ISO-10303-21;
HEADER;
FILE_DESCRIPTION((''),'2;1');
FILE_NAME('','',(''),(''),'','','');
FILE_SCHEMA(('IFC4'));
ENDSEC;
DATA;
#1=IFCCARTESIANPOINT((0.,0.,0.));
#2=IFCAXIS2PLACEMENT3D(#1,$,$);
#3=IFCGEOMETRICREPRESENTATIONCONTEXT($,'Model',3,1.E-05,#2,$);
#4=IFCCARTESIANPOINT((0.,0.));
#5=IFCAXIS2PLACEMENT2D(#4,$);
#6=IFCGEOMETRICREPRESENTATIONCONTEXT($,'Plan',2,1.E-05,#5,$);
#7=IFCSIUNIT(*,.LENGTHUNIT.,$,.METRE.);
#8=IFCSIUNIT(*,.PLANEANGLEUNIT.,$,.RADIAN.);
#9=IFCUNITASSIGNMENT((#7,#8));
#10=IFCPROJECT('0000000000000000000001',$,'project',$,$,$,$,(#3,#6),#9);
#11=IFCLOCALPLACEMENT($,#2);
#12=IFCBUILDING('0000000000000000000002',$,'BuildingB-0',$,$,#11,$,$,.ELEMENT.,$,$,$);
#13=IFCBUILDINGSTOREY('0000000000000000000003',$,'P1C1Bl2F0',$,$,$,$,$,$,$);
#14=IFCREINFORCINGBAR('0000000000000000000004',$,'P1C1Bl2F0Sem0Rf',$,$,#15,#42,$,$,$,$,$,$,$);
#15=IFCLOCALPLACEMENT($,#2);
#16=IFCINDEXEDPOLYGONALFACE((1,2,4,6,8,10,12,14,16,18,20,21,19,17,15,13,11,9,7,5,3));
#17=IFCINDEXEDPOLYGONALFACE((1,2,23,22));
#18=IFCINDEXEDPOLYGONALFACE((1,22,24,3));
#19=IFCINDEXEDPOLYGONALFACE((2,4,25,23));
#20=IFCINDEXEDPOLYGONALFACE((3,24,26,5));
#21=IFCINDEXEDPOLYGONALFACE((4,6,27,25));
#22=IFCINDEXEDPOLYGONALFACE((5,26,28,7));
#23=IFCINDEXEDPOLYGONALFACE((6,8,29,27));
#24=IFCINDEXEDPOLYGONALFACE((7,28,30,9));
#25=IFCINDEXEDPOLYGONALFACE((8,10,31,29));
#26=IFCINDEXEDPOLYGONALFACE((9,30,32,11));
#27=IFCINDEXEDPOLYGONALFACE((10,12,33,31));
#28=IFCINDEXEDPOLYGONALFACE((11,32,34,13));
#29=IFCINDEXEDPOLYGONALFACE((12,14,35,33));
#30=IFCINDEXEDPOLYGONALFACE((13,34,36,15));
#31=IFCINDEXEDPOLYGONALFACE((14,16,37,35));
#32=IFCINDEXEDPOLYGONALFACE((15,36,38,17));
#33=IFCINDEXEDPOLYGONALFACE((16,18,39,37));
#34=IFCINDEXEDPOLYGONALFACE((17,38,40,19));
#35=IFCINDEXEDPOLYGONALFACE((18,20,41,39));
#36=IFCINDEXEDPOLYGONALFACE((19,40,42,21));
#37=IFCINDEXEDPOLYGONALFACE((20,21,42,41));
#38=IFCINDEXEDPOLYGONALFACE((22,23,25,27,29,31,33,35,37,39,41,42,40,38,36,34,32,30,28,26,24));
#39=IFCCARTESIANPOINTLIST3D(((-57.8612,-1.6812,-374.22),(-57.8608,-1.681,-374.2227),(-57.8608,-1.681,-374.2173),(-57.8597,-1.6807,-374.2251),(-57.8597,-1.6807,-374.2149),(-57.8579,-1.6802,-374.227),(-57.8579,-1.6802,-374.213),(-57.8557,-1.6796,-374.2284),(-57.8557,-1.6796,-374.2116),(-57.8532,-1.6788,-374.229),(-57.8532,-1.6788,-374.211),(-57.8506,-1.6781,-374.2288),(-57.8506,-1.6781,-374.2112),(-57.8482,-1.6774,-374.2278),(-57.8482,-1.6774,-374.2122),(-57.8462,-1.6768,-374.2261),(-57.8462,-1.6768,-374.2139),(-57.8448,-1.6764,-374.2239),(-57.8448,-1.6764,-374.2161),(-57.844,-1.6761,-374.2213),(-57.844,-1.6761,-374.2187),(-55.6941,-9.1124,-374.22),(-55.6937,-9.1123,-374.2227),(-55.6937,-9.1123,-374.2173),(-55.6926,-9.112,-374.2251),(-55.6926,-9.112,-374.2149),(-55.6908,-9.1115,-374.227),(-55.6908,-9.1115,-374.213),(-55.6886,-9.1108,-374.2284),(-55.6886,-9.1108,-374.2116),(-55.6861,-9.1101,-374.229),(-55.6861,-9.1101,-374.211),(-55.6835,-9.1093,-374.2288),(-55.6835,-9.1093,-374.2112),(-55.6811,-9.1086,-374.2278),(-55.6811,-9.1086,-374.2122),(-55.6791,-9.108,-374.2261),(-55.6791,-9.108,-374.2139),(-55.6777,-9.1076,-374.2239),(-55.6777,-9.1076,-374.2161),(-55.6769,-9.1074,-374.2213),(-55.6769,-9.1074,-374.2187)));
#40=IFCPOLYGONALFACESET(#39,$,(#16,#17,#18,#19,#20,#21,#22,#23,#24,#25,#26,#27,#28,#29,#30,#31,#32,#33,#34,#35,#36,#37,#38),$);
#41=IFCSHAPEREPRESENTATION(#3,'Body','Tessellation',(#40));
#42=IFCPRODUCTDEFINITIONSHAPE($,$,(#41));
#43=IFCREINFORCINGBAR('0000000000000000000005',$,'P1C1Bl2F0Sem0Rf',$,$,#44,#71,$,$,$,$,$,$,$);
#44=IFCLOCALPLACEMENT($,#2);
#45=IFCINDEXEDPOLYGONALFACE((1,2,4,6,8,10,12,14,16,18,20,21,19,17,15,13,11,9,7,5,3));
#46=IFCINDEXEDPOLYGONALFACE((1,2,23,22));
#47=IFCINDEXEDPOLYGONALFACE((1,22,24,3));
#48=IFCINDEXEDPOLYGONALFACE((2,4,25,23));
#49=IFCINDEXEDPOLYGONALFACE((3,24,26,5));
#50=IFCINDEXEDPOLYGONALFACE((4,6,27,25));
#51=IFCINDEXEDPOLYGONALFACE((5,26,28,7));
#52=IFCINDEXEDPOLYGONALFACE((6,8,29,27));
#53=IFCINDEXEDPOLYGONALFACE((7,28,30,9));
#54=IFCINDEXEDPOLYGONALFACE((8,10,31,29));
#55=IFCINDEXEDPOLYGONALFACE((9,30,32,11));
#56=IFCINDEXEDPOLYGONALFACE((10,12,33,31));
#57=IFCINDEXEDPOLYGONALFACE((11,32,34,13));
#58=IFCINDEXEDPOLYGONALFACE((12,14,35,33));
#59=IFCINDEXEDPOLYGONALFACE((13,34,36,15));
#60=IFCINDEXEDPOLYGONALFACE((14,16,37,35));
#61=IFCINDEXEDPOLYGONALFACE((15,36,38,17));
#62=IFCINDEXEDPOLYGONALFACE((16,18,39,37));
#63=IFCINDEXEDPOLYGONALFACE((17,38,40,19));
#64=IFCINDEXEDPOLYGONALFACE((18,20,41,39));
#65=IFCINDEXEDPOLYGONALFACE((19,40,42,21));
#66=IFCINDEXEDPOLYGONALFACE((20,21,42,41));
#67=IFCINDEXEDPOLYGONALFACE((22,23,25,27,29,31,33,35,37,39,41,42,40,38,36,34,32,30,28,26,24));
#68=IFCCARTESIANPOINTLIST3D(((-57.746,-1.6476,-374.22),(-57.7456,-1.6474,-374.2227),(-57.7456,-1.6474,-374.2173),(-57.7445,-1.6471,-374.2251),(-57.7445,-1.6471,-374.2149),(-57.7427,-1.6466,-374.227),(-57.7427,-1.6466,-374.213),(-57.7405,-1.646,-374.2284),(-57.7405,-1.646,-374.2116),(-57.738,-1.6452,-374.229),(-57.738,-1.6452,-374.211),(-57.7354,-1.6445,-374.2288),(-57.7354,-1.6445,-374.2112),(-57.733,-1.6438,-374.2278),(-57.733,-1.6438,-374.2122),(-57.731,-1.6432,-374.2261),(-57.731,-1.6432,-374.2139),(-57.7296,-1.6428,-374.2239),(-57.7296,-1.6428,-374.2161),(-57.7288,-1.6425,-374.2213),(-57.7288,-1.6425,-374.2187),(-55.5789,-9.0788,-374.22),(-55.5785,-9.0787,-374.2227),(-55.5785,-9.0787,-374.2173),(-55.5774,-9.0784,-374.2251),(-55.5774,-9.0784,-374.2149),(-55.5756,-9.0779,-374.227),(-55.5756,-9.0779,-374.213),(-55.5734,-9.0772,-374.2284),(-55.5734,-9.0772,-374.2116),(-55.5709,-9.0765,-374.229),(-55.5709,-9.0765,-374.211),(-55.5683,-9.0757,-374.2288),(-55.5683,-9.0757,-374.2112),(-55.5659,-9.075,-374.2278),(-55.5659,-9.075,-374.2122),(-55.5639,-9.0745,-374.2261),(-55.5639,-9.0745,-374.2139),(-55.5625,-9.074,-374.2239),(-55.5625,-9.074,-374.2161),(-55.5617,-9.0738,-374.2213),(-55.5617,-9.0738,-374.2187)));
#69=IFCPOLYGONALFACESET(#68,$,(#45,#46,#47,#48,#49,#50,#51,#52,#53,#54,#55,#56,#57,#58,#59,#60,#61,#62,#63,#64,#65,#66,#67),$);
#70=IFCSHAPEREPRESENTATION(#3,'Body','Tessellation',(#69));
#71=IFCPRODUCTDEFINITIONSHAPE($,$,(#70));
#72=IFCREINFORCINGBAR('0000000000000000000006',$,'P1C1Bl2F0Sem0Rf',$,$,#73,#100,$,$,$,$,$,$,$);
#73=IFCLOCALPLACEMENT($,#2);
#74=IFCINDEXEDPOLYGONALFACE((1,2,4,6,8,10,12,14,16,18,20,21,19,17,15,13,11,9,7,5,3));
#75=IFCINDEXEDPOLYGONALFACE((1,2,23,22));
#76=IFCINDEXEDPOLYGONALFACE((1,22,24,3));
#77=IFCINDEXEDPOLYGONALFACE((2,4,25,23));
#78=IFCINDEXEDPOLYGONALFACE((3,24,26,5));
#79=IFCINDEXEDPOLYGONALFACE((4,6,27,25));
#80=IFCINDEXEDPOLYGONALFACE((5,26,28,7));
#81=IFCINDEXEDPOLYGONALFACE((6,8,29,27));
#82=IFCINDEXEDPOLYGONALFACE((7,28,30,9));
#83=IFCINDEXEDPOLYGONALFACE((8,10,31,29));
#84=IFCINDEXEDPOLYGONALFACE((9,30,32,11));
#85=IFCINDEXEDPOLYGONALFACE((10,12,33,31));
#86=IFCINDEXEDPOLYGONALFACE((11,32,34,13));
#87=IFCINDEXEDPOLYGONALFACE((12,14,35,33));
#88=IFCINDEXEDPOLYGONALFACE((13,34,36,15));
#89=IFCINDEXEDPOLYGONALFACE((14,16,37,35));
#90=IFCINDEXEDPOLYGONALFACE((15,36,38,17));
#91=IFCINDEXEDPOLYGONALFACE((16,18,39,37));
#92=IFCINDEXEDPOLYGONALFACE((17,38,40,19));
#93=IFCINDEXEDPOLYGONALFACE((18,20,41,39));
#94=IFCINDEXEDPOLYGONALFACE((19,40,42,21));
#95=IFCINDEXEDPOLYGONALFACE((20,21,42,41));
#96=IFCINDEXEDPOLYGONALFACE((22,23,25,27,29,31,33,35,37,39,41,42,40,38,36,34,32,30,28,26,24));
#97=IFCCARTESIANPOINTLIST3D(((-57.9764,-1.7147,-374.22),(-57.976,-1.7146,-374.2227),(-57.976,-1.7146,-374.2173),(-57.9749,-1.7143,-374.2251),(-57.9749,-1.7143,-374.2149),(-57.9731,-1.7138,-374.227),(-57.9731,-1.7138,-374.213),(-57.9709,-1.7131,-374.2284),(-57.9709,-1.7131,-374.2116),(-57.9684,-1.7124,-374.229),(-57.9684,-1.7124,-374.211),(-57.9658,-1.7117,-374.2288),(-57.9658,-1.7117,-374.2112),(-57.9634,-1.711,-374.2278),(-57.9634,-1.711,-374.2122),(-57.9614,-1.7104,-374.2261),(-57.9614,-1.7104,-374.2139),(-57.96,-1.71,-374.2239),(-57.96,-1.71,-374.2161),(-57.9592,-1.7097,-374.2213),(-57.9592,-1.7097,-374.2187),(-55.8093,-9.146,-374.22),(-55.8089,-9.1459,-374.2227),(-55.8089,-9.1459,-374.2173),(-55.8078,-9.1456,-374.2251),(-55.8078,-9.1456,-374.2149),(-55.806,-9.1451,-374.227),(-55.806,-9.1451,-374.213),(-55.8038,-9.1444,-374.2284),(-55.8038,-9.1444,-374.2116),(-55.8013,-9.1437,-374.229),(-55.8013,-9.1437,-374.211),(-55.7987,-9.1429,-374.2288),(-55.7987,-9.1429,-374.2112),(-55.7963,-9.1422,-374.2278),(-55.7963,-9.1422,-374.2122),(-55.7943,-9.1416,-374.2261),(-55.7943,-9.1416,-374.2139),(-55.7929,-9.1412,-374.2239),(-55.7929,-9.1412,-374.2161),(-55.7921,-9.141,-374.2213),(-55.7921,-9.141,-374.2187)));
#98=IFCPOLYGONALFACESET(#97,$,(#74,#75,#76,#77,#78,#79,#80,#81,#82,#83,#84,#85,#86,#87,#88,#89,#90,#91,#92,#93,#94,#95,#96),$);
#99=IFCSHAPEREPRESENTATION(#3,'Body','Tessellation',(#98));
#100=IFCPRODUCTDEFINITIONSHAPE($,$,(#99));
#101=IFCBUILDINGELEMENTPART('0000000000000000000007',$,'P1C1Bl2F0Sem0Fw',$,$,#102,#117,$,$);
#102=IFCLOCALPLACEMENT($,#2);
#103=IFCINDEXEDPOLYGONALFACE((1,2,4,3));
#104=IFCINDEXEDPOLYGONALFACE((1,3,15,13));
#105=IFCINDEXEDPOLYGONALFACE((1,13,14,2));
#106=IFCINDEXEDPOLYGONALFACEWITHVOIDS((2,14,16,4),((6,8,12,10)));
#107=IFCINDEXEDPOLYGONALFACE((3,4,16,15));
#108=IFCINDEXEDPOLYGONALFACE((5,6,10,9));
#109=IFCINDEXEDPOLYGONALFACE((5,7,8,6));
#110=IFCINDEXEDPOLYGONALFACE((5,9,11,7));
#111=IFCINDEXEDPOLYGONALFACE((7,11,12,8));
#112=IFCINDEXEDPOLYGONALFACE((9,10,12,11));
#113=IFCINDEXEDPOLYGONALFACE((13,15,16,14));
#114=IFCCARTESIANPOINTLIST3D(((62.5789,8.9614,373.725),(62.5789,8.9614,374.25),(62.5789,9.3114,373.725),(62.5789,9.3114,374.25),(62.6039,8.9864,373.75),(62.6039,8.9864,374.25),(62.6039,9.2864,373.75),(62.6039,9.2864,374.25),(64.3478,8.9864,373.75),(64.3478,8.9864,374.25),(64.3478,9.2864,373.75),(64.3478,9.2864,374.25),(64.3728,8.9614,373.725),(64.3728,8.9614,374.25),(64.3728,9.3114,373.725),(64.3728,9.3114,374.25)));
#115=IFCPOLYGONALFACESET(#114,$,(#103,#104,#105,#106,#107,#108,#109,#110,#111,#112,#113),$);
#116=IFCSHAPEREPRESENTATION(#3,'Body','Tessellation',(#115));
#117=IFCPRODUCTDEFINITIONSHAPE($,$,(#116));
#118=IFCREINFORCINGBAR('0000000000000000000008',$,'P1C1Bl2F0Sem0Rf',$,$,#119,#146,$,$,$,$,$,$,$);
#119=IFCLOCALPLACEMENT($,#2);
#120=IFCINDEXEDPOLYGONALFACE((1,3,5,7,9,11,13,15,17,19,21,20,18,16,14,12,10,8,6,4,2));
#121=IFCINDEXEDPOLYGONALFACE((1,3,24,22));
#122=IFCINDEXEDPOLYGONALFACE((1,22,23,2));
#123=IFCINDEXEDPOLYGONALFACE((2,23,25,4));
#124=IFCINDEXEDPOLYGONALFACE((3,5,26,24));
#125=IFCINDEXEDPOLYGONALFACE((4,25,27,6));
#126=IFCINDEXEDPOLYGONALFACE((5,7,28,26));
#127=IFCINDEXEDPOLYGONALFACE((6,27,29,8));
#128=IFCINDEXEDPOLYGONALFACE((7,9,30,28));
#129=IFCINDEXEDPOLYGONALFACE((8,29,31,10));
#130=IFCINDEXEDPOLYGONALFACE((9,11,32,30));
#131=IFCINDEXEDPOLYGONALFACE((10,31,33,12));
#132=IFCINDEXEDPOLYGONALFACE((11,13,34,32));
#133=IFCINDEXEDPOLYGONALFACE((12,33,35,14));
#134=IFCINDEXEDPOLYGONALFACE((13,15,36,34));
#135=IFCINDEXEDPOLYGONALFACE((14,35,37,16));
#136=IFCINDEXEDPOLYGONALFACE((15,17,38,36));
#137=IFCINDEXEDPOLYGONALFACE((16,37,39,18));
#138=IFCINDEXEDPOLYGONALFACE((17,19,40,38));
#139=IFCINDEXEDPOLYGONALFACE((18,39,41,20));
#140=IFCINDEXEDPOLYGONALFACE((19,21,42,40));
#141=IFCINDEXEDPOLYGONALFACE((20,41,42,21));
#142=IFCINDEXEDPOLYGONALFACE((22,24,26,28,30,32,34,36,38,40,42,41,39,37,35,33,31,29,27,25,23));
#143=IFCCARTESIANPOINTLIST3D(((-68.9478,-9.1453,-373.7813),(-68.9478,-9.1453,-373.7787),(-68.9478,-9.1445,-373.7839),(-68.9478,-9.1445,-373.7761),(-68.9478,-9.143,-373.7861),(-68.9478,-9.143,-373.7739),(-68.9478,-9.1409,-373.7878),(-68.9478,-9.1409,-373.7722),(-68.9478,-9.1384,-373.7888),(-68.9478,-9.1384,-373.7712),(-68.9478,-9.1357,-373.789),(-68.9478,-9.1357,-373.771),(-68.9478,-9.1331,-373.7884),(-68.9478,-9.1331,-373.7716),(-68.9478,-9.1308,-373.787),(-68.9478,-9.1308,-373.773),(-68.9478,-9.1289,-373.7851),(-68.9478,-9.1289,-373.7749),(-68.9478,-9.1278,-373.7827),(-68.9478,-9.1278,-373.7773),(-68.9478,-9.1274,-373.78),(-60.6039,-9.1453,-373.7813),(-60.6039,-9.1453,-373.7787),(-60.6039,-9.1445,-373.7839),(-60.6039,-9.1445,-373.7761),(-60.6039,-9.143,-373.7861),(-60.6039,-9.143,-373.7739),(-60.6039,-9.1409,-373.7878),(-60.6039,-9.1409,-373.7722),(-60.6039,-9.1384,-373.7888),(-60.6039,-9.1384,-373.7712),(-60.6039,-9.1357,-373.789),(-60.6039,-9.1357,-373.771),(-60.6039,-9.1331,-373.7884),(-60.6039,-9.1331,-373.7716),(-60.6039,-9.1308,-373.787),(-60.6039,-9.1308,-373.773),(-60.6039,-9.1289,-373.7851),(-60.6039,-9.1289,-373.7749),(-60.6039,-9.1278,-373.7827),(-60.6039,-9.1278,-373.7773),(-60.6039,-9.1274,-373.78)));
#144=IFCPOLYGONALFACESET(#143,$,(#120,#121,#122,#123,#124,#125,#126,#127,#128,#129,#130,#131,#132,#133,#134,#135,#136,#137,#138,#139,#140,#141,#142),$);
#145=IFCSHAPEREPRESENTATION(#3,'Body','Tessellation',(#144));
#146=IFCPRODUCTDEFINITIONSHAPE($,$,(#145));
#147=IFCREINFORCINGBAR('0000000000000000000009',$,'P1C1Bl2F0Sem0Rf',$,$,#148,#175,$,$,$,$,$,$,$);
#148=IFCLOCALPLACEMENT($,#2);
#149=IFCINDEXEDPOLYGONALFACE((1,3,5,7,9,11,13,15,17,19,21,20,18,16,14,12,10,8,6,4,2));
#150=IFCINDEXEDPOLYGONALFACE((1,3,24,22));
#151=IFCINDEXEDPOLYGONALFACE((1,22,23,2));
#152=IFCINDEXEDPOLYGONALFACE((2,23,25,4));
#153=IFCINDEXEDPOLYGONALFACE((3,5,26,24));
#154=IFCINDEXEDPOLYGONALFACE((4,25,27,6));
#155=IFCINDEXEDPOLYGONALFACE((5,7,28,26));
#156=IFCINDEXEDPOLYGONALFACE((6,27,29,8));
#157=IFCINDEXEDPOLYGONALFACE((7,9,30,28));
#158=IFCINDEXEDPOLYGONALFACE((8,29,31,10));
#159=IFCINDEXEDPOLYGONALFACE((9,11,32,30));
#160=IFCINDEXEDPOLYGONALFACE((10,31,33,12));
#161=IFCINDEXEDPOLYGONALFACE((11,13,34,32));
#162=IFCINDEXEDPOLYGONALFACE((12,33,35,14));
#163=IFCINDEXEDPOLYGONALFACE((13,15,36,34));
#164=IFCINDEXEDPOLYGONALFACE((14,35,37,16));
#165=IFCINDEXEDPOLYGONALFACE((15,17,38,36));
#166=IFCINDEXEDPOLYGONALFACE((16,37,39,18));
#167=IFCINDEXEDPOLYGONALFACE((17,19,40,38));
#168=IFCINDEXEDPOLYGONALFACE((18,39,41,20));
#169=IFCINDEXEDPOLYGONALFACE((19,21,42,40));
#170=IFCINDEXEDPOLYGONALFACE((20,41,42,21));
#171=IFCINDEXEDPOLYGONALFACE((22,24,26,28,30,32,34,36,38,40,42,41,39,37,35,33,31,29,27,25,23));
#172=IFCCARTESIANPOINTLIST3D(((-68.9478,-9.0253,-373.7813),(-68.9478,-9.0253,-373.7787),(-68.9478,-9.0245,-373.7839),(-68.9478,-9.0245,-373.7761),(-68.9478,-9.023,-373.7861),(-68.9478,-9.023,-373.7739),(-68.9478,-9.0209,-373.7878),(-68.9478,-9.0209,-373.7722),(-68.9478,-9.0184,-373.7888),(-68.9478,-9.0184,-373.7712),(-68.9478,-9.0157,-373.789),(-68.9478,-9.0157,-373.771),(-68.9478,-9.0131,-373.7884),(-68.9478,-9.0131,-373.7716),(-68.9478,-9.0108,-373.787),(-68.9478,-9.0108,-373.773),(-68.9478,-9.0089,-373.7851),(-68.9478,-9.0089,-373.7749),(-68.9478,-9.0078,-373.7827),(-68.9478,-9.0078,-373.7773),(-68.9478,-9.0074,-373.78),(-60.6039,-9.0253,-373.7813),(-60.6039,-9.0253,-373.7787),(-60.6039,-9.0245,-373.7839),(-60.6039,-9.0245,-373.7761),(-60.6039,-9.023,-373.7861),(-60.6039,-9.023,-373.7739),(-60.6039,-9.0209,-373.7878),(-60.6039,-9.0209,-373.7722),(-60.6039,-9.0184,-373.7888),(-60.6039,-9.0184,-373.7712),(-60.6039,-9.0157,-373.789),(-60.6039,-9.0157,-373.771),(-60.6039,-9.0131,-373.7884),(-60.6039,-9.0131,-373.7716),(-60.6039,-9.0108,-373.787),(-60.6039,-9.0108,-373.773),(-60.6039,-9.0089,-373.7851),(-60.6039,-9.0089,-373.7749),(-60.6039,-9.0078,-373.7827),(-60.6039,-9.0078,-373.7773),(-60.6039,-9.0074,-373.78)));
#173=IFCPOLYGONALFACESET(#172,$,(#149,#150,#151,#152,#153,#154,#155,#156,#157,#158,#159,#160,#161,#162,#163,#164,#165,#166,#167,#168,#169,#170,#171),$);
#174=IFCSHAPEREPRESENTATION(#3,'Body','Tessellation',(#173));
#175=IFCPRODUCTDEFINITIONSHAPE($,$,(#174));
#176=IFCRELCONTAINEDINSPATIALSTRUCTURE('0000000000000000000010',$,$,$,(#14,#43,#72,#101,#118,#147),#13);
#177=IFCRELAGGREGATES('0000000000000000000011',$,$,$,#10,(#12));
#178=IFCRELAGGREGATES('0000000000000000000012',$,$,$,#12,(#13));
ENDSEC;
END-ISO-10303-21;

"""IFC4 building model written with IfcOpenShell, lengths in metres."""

from ifc_helpers import new_model, entity, si_unit, origin, origin_2d, place, context, project, spatial, polyline, outline, extrude, element, save


model = new_model("IFC4")

# Units and contexts
model_context = context("Model", 3, precision=1e-05, world=origin())
plan_context = context("Plan", 2, precision=1e-05, world=origin_2d())
ifc_project = project(units=[si_unit("LENGTHUNIT", "METRE"), si_unit("PLANEANGLEUNIT", "RADIAN")], contexts=[model_context, plan_context])

# Building, storey
building_placement = place(None, origin())
building = spatial("IfcBuilding", under=ifc_project, at=building_placement, Name="BuildingB-0", CompositionType="ELEMENT")
storey = spatial("IfcBuildingStorey", under=building, Name="P1C1Bl2F0")

# Reinforcing bars
element("IfcReinforcingBar", 1, inside=storey, Name="P1C1Bl2F0Sem0Rf", context=model_context, shape_type="SweptSolid", body=[
    entity("IfcSurfaceCurveSweptAreaSolid", entity("IfcCircleProfileDef", "AREA", None, None, 0.009), None, entity("IfcPolyline", [entity("IfcCartesianPoint", [55.6854, 9.1099, 374.22]), entity("IfcCartesianPoint", [57.8525, 1.6786, 374.22])]), None, None, entity("IfcPlane", entity("IfcAxis2Placement3D", entity("IfcCartesianPoint", [55.6854, 9.1099, 374.22]), entity("IfcDirection", [0.0, 0.0, 1.0]), entity("IfcDirection", [1.0, 0.0, 0.0])))),
])
element("IfcReinforcingBar", 2, inside=storey, Name="P1C1Bl2F0Sem0Rf", context=model_context, shape_type="SweptSolid", body=[
    entity("IfcSurfaceCurveSweptAreaSolid", entity("IfcCircleProfileDef", "AREA", None, None, 0.009), None, entity("IfcPolyline", [entity("IfcCartesianPoint", [55.5702, 9.0763, 374.22]), entity("IfcCartesianPoint", [57.7373, 1.645, 374.22])]), None, None, entity("IfcPlane", entity("IfcAxis2Placement3D", entity("IfcCartesianPoint", [55.5702, 9.0763, 374.22]), entity("IfcDirection", [0.0, 0.0, 1.0]), entity("IfcDirection", [1.0, 0.0, 0.0])))),
])
element("IfcReinforcingBar", 3, inside=storey, Name="P1C1Bl2F0Sem0Rf", context=model_context, shape_type="SweptSolid", body=[
    entity("IfcSurfaceCurveSweptAreaSolid", entity("IfcCircleProfileDef", "AREA", None, None, 0.009), None, entity("IfcPolyline", [entity("IfcCartesianPoint", [55.8006, 9.1435, 374.22]), entity("IfcCartesianPoint", [57.9677, 1.7122, 374.22])]), None, None, entity("IfcPlane", entity("IfcAxis2Placement3D", entity("IfcCartesianPoint", [55.8006, 9.1435, 374.22]), entity("IfcDirection", [0.0, 0.0, 1.0]), entity("IfcDirection", [1.0, 0.0, 0.0])))),
])

# Building element part, opening
building_element_part_1 = element("IfcBuildingElementPart", 4, inside=storey, Name="P1C1Bl2F0Sem0Fw", context=model_context, shape_type="SweptSolid", body=[
    extrude(outline(polyline([(64.3728, 8.9614, 373.725), (62.5789, 8.9614, 373.725), (62.5789, 9.3114, 373.725), (64.3728, 9.3114, 373.725), (64.3728, 8.9614, 373.725)])), None, (0.0, 0.0, 1.0), 0.525),
])
element("IfcOpeningElement", 5, inside=storey, cuts=building_element_part_1, context=model_context, shape_type="SweptSolid", body=[
    extrude(outline(polyline([(64.3478, 8.9864, 373.75), (62.6039, 8.9864, 373.75), (62.6039, 9.2864, 373.75), (64.3478, 9.2864, 373.75), (64.3478, 8.9864, 373.75)])), None, (0.0, 0.0, 1.0), 0.5),
])

# Reinforcing bars
element("IfcReinforcingBar", 6, inside=storey, Name="P1C1Bl2F0Sem0Rf", context=model_context, shape_type="SweptSolid", body=[
    entity("IfcSurfaceCurveSweptAreaSolid", entity("IfcCircleProfileDef", "AREA", None, None, 0.009), None, entity("IfcPolyline", [entity("IfcCartesianPoint", [60.6039, 9.1364, 373.78]), entity("IfcCartesianPoint", [68.9478, 9.1364, 373.78])]), None, None, entity("IfcPlane", entity("IfcAxis2Placement3D", entity("IfcCartesianPoint", [60.6039, 9.1364, 373.78]), entity("IfcDirection", [0.0, 0.0, 1.0]), entity("IfcDirection", [1.0, 0.0, 0.0])))),
])
element("IfcReinforcingBar", 7, inside=storey, Name="P1C1Bl2F0Sem0Rf", context=model_context, shape_type="SweptSolid", body=[
    entity("IfcSurfaceCurveSweptAreaSolid", entity("IfcCircleProfileDef", "AREA", None, None, 0.009), None, entity("IfcPolyline", [entity("IfcCartesianPoint", [60.6039, 9.0164, 373.78]), entity("IfcCartesianPoint", [68.9478, 9.0164, 373.78])]), None, None, entity("IfcPlane", entity("IfcAxis2Placement3D", entity("IfcCartesianPoint", [60.6039, 9.0164, 373.78]), entity("IfcDirection", [0.0, 0.0, 1.0]), entity("IfcDirection", [1.0, 0.0, 0.0])))),
])

save(model, "model.ifc")
